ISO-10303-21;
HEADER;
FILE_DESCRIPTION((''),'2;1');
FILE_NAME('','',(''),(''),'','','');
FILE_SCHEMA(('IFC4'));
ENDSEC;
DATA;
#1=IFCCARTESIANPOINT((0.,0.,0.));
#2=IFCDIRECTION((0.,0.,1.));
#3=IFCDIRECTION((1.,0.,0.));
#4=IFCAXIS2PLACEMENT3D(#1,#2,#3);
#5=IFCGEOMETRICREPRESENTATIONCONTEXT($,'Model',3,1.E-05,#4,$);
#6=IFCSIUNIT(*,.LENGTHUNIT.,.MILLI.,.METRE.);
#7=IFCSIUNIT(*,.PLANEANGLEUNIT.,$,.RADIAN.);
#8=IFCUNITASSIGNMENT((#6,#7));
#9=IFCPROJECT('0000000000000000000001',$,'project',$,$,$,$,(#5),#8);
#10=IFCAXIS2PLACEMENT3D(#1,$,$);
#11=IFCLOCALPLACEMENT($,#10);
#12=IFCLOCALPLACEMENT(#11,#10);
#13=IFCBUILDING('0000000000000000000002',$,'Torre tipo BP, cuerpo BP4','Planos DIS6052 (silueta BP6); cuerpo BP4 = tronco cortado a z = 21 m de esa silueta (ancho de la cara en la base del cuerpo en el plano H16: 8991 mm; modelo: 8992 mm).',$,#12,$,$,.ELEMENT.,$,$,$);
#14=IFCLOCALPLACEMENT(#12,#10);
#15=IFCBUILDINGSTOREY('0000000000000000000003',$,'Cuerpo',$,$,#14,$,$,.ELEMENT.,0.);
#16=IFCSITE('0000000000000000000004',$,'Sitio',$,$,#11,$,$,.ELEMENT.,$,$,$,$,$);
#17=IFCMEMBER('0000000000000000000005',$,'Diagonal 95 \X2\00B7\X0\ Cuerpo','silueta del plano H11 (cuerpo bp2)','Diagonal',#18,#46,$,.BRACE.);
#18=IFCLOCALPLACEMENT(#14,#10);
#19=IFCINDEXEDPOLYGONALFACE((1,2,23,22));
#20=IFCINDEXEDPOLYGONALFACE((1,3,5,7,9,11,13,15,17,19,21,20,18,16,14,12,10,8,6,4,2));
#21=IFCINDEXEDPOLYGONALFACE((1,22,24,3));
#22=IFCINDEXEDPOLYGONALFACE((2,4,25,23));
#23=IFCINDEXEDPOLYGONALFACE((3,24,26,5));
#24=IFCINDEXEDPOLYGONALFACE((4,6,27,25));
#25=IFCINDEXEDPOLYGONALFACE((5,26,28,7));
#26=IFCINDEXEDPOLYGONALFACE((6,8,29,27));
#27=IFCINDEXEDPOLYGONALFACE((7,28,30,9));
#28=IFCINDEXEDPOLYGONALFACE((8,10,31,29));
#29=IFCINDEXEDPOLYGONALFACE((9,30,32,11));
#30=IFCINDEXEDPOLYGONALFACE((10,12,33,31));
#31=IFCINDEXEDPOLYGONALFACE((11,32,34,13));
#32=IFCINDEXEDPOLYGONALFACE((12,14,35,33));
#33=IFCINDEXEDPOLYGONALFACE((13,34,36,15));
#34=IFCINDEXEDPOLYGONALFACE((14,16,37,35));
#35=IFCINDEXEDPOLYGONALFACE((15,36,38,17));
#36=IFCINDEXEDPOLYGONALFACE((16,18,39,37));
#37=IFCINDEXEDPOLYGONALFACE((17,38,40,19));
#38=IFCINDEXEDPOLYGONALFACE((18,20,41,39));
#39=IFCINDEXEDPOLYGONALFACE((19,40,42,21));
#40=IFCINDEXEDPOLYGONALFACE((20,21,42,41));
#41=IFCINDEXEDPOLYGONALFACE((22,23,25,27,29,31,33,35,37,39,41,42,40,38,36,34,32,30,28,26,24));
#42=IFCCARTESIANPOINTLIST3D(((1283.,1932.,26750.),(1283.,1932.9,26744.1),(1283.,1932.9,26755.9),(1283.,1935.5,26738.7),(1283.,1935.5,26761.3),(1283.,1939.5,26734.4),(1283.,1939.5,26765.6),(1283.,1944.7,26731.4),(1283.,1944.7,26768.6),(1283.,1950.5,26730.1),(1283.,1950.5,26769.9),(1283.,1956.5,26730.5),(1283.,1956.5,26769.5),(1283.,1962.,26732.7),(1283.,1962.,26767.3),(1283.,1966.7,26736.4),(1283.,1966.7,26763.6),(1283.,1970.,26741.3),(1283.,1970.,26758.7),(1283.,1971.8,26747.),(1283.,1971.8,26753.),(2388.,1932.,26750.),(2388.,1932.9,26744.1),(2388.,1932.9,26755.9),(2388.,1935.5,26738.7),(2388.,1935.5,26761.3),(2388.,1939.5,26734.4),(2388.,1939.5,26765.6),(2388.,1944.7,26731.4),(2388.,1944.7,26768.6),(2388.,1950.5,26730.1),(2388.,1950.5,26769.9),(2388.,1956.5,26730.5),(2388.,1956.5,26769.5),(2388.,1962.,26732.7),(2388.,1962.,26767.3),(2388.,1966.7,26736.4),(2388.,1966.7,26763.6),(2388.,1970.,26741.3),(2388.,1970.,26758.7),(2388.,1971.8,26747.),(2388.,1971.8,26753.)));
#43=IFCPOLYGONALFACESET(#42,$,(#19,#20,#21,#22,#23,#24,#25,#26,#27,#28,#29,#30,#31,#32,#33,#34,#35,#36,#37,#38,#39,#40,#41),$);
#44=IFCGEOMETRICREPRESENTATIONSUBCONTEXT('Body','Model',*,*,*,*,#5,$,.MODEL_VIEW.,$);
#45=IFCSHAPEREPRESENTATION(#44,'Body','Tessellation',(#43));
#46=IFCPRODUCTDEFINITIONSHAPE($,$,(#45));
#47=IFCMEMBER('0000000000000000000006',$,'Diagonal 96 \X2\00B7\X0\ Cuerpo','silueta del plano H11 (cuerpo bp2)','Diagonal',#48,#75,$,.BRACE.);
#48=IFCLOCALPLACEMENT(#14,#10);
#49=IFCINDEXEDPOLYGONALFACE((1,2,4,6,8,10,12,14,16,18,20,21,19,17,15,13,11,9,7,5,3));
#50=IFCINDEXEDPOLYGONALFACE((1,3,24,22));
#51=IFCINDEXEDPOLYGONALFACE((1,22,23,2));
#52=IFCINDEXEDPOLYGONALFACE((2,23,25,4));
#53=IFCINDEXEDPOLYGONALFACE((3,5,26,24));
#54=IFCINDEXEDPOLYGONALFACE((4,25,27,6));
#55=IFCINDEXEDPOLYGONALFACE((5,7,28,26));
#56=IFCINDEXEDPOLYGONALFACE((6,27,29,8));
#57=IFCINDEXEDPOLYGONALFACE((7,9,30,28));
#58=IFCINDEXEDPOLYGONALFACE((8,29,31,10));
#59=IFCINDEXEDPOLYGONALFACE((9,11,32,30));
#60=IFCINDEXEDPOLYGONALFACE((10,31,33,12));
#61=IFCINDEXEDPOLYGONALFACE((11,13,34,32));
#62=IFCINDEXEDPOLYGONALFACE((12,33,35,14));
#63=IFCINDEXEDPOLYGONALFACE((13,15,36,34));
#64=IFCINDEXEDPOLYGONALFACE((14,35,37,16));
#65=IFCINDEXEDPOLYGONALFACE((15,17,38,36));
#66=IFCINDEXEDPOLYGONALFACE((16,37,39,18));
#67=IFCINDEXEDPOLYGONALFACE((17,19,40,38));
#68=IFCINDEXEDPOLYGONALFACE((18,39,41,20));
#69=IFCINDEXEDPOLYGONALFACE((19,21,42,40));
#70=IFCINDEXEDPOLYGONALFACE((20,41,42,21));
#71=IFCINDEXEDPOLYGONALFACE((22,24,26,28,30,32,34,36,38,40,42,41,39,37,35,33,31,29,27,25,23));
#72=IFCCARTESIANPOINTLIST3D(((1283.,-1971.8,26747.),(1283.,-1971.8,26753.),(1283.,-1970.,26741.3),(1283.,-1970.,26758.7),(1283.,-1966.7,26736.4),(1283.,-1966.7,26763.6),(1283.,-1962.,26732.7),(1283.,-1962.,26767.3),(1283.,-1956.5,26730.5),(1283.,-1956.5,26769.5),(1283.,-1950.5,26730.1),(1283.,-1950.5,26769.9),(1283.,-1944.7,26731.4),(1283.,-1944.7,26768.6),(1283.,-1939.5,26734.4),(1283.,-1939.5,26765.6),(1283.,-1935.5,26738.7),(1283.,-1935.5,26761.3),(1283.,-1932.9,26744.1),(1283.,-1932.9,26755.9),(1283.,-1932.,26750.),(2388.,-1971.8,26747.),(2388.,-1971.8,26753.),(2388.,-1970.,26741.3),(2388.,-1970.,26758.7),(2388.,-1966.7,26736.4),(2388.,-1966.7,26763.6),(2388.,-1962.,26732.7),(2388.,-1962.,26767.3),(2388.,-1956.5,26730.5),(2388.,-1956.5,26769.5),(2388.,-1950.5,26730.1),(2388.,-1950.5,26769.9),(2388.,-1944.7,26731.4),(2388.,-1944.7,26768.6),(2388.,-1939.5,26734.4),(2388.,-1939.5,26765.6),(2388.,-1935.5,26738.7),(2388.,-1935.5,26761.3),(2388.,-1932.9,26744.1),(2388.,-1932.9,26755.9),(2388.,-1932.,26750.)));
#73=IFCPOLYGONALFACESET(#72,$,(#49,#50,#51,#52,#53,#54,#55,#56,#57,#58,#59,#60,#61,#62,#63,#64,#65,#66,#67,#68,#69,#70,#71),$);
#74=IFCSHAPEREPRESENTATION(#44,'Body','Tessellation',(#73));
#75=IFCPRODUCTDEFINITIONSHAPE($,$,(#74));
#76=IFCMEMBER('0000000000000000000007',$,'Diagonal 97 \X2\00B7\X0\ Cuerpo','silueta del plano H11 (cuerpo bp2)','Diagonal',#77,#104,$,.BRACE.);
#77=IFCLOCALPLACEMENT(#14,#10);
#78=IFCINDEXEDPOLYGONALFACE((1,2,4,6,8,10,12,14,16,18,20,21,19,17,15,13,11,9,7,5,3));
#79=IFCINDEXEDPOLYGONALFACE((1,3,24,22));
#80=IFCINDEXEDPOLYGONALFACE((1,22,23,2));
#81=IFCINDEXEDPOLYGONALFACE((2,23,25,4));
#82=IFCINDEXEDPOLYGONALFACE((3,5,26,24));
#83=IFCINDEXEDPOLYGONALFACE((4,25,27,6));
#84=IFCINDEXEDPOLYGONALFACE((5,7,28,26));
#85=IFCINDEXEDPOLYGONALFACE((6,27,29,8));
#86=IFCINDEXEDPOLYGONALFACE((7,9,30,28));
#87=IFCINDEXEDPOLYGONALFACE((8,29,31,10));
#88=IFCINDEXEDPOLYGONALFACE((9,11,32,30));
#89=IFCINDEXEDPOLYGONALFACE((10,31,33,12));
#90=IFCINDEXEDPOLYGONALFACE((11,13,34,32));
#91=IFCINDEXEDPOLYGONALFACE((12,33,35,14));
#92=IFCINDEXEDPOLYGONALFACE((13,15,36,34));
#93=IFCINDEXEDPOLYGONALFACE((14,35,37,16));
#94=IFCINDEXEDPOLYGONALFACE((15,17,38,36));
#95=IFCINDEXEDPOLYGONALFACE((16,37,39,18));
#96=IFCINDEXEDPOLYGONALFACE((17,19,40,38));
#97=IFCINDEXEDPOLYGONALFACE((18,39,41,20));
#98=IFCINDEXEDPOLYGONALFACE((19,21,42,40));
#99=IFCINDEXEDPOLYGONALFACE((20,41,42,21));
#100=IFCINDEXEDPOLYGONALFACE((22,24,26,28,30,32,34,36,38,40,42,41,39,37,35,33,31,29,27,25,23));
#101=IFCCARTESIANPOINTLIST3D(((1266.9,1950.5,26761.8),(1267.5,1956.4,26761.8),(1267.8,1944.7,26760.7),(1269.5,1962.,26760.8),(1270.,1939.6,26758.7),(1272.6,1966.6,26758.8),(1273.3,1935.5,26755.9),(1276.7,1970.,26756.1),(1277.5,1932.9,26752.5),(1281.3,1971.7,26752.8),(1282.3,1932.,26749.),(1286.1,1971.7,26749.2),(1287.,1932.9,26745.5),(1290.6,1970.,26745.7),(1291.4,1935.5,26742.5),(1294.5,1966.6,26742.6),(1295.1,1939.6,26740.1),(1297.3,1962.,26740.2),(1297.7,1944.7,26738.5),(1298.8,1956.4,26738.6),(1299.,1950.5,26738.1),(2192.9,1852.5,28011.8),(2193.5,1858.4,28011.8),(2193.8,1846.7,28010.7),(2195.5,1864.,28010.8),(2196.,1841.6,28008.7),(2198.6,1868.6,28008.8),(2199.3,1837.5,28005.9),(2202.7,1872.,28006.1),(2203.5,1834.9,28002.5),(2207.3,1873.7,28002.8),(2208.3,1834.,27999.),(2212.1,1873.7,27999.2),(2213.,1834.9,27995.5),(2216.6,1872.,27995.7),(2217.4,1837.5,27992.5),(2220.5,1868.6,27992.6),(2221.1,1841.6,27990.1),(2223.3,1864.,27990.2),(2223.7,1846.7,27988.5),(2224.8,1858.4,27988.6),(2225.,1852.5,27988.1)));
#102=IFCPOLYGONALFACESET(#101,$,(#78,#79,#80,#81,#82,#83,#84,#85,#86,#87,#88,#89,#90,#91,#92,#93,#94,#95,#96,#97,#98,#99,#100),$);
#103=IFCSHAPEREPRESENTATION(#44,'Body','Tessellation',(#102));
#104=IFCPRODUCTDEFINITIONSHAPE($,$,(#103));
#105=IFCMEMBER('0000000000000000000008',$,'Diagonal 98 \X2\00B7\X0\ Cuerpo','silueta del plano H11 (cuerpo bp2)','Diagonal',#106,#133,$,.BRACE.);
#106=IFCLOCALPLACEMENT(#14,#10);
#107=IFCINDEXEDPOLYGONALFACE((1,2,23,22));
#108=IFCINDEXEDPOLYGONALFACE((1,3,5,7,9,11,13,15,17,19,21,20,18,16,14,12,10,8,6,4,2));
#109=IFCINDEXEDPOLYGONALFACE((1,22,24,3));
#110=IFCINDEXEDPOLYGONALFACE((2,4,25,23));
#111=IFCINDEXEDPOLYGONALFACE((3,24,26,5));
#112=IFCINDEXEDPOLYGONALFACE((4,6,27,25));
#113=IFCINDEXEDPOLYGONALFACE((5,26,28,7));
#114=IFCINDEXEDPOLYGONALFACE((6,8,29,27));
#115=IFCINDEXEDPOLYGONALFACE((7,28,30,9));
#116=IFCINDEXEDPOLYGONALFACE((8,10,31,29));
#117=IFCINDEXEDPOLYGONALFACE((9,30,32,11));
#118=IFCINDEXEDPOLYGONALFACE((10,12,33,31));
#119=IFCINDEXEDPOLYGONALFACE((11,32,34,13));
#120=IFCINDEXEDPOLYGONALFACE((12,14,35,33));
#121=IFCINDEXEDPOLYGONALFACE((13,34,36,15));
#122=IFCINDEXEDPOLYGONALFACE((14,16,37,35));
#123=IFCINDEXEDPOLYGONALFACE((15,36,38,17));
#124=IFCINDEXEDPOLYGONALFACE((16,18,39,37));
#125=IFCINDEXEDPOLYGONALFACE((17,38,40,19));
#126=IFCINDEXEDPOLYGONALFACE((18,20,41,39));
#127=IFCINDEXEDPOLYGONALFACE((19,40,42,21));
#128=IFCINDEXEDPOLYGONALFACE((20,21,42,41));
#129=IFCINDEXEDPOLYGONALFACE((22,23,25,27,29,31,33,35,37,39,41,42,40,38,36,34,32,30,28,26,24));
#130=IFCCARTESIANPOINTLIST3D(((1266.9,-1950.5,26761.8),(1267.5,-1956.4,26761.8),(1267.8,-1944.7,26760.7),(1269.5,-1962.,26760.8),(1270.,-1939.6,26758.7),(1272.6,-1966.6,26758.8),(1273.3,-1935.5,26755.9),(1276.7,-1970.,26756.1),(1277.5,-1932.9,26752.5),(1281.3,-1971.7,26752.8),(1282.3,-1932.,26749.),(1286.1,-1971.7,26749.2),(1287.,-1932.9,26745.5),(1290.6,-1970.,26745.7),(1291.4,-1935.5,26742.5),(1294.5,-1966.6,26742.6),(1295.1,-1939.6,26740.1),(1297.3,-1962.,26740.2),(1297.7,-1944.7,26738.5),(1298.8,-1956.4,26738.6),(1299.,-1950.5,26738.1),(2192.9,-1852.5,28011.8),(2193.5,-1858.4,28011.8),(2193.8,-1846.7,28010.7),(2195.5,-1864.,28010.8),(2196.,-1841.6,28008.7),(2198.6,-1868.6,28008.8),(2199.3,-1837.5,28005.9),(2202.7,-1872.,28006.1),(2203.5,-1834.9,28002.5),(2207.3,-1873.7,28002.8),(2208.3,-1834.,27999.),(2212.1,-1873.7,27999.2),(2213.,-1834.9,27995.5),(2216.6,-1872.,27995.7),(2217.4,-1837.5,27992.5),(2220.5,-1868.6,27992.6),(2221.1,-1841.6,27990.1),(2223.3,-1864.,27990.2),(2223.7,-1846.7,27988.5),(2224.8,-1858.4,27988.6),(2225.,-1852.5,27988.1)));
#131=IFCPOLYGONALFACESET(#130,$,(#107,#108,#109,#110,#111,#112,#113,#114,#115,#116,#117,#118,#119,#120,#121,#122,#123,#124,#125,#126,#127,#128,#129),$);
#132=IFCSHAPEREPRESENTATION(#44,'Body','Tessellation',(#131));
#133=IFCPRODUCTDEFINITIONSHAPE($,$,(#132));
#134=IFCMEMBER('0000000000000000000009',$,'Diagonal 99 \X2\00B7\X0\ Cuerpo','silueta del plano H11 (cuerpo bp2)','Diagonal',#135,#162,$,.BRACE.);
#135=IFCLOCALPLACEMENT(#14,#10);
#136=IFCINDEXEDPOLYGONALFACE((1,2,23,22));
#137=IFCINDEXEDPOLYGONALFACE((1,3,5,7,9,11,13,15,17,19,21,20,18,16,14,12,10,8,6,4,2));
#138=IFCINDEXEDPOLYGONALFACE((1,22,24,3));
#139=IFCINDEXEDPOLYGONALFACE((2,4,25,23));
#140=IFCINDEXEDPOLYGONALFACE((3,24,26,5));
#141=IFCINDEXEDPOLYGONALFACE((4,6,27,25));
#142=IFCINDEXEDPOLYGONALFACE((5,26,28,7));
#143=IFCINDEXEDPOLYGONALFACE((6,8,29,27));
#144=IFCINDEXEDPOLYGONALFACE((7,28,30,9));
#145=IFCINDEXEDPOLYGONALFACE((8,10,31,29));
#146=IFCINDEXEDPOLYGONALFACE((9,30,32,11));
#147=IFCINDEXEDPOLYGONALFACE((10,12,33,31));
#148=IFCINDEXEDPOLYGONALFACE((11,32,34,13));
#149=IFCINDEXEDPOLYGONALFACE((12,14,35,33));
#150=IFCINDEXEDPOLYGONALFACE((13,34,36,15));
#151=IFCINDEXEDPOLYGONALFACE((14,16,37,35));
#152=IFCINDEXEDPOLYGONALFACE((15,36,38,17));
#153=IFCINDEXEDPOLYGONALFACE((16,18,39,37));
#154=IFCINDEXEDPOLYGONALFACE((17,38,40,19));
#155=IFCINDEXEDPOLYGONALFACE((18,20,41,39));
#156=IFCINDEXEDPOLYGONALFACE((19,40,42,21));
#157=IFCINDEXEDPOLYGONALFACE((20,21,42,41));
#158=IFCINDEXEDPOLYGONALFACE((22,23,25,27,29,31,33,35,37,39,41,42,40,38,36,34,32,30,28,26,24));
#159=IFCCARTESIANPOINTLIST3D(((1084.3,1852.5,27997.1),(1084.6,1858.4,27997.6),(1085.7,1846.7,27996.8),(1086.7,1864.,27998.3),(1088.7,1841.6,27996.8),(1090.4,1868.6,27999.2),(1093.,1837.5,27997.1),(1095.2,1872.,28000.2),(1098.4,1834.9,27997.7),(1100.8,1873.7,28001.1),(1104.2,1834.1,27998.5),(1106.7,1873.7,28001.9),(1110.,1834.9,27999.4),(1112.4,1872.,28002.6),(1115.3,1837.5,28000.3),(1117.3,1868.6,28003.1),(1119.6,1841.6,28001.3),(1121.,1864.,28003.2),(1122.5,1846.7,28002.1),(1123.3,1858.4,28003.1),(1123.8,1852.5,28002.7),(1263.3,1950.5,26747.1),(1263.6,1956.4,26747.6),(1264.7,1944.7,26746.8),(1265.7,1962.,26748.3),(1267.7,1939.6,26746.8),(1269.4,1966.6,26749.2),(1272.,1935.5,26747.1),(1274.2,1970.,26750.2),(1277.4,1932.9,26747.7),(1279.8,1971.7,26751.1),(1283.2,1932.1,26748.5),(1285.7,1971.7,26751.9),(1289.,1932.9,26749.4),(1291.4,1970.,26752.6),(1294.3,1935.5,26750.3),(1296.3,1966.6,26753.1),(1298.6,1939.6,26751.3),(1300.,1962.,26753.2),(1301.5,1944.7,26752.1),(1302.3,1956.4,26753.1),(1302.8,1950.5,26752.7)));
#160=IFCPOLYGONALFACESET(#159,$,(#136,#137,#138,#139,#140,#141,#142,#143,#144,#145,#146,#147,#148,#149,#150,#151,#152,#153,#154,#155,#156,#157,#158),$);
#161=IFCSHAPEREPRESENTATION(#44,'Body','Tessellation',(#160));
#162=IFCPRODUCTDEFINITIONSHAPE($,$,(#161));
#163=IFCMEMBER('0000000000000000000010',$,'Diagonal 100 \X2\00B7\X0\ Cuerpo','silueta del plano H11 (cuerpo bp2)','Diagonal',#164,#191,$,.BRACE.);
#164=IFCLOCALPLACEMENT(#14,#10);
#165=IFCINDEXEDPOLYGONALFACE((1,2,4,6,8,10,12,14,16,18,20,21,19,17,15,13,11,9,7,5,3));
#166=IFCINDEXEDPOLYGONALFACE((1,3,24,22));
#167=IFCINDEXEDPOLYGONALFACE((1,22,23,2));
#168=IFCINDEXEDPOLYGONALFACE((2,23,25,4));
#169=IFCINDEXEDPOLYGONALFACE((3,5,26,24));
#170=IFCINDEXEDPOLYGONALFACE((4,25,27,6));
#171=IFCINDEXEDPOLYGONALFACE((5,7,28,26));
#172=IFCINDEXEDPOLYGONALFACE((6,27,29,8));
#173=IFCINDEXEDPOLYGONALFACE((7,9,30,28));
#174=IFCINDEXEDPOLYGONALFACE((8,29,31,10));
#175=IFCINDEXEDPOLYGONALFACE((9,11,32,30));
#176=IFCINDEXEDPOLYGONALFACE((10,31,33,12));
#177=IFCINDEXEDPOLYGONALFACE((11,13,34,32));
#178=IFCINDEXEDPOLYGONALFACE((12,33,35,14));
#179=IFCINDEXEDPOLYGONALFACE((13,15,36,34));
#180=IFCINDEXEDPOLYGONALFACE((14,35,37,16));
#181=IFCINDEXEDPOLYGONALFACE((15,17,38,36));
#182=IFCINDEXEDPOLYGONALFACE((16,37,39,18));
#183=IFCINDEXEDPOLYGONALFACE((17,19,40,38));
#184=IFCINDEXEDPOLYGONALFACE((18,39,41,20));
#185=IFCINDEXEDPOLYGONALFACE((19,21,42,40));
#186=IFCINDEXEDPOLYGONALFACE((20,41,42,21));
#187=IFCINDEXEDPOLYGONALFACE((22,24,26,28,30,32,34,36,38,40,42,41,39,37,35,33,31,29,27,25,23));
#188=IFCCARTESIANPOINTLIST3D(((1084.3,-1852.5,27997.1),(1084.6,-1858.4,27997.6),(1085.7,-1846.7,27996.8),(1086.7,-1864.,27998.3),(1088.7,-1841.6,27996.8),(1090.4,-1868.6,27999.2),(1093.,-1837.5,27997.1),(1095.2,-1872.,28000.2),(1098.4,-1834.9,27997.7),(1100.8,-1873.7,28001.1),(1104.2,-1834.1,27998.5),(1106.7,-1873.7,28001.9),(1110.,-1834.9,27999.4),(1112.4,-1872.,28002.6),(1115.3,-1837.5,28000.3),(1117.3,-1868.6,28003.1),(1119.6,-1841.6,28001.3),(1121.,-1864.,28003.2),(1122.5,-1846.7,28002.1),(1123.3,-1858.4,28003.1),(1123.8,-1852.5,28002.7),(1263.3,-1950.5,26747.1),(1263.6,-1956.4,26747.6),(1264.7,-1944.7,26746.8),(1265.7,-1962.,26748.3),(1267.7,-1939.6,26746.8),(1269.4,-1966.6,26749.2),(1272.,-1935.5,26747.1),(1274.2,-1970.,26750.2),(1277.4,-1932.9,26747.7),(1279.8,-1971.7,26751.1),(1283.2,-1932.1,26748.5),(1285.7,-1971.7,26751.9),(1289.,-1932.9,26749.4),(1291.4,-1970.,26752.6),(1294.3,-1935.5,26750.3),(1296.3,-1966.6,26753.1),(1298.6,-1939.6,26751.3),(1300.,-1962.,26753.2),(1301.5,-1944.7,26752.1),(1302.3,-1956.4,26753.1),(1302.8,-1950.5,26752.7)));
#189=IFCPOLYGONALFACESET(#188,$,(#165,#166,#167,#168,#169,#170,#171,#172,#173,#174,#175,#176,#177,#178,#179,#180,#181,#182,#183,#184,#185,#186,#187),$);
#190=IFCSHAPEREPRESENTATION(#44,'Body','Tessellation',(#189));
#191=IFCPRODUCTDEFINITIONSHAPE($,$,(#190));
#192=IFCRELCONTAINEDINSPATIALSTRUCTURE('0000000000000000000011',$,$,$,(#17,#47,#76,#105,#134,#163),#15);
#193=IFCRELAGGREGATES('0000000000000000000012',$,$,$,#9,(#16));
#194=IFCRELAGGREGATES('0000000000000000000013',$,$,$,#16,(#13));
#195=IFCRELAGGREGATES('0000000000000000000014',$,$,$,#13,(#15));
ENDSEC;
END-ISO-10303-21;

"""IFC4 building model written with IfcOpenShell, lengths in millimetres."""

from ifc_helpers import new_model, si_unit, frame, origin, origin_with_axes, place, context, subcontext, project, spatial, circle, extrude, element, save


model = new_model("IFC4")

# Units and contexts
model_context = context("Model", 3, precision=1e-05, world=origin_with_axes())
body_context = subcontext(model_context, "Body", "Model", "MODEL_VIEW")
ifc_project = project(units=[si_unit("LENGTHUNIT", "METRE", prefix="MILLI"), si_unit("PLANEANGLEUNIT", "RADIAN")], contexts=[model_context])

# Site, building, storey
site_placement = place(None, origin())
site = spatial("IfcSite", under=ifc_project, at=site_placement, Name="Sitio", CompositionType="ELEMENT")
building_placement = place(site_placement, origin())
building = spatial("IfcBuilding", under=site, at=building_placement, Name="Torre tipo BP, cuerpo BP4", Description="Planos DIS6052 (silueta BP6); cuerpo BP4 = tronco cortado a z = 21 m de esa silueta (ancho de la cara en la base del cuerpo en el plano H16: 8991 mm; modelo: 8992 mm).", CompositionType="ELEMENT")
storey_placement = place(building_placement, origin())
storey = spatial("IfcBuildingStorey", under=building, at=storey_placement, Name="Cuerpo", CompositionType="ELEMENT", Elevation=0.0)

# Members
for number, where, z_axis, x_axis, name in (
    (1, (2388.0, 1952.0, 26750.0), (-1.0, 0.0, 0.0), (0.0, -1.0, 0.0), "Diagonal 95 · Cuerpo"),
    (2, (2388.0, -1952.0, 26750.0), (-1.0, 0.0, 0.0), (0.0, 1.0, 0.0), "Diagonal 96 · Cuerpo"),
):
    element("IfcMember", number, at=place(storey_placement, frame(where, z_axis=z_axis, x_axis=x_axis)), inside=storey, Name=name, Description="silueta del plano H11 (cuerpo bp2)", ObjectType="Diagonal", PredefinedType="BRACE", context=body_context, shape_type="SweptSolid", body=[
        extrude(circle(Radius=20.0), None, (0.0, 0.0, 1.0), 1105.0),
    ])
for number, where, z_axis, x_axis, name in (
    (3, (2209.0, 1854.0, 28000.0), (-0.594081, 0.062872, -0.801945), (-0.037425, -0.998022, -0.05052), "Diagonal 97 · Cuerpo"),
    (4, (2209.0, -1854.0, 28000.0), (-0.594081, -0.062872, -0.801945), (-0.037425, 0.998022, -0.05052), "Diagonal 98 · Cuerpo"),
):
    element("IfcMember", number, at=place(storey_placement, frame(where, z_axis=z_axis, x_axis=x_axis)), inside=storey, Name=name, Description="silueta del plano H11 (cuerpo bp2)", ObjectType="Diagonal", PredefinedType="BRACE", context=body_context, shape_type="SweptSolid", body=[
        extrude(circle(Radius=20.0), None, (0.0, 0.0, 1.0), 1558.7),
    ])
for number, where, z_axis, x_axis, name in (
    (5, (1283.0, 1952.0, 26750.0), (-0.141329, -0.077376, 0.986934), (0.010968, -0.997002, -0.076594), "Diagonal 99 · Cuerpo"),
    (6, (1283.0, -1952.0, 26750.0), (-0.141329, 0.077376, 0.986934), (0.010968, 0.997002, -0.076594), "Diagonal 100 · Cuerpo"),
):
    element("IfcMember", number, at=place(storey_placement, frame(where, z_axis=z_axis, x_axis=x_axis)), inside=storey, Name=name, Description="silueta del plano H11 (cuerpo bp2)", ObjectType="Diagonal", PredefinedType="BRACE", context=body_context, shape_type="SweptSolid", body=[
        extrude(circle(Radius=20.0), None, (0.0, 0.0, 1.0), 1266.5),
    ])

save(model, "model.ifc")
